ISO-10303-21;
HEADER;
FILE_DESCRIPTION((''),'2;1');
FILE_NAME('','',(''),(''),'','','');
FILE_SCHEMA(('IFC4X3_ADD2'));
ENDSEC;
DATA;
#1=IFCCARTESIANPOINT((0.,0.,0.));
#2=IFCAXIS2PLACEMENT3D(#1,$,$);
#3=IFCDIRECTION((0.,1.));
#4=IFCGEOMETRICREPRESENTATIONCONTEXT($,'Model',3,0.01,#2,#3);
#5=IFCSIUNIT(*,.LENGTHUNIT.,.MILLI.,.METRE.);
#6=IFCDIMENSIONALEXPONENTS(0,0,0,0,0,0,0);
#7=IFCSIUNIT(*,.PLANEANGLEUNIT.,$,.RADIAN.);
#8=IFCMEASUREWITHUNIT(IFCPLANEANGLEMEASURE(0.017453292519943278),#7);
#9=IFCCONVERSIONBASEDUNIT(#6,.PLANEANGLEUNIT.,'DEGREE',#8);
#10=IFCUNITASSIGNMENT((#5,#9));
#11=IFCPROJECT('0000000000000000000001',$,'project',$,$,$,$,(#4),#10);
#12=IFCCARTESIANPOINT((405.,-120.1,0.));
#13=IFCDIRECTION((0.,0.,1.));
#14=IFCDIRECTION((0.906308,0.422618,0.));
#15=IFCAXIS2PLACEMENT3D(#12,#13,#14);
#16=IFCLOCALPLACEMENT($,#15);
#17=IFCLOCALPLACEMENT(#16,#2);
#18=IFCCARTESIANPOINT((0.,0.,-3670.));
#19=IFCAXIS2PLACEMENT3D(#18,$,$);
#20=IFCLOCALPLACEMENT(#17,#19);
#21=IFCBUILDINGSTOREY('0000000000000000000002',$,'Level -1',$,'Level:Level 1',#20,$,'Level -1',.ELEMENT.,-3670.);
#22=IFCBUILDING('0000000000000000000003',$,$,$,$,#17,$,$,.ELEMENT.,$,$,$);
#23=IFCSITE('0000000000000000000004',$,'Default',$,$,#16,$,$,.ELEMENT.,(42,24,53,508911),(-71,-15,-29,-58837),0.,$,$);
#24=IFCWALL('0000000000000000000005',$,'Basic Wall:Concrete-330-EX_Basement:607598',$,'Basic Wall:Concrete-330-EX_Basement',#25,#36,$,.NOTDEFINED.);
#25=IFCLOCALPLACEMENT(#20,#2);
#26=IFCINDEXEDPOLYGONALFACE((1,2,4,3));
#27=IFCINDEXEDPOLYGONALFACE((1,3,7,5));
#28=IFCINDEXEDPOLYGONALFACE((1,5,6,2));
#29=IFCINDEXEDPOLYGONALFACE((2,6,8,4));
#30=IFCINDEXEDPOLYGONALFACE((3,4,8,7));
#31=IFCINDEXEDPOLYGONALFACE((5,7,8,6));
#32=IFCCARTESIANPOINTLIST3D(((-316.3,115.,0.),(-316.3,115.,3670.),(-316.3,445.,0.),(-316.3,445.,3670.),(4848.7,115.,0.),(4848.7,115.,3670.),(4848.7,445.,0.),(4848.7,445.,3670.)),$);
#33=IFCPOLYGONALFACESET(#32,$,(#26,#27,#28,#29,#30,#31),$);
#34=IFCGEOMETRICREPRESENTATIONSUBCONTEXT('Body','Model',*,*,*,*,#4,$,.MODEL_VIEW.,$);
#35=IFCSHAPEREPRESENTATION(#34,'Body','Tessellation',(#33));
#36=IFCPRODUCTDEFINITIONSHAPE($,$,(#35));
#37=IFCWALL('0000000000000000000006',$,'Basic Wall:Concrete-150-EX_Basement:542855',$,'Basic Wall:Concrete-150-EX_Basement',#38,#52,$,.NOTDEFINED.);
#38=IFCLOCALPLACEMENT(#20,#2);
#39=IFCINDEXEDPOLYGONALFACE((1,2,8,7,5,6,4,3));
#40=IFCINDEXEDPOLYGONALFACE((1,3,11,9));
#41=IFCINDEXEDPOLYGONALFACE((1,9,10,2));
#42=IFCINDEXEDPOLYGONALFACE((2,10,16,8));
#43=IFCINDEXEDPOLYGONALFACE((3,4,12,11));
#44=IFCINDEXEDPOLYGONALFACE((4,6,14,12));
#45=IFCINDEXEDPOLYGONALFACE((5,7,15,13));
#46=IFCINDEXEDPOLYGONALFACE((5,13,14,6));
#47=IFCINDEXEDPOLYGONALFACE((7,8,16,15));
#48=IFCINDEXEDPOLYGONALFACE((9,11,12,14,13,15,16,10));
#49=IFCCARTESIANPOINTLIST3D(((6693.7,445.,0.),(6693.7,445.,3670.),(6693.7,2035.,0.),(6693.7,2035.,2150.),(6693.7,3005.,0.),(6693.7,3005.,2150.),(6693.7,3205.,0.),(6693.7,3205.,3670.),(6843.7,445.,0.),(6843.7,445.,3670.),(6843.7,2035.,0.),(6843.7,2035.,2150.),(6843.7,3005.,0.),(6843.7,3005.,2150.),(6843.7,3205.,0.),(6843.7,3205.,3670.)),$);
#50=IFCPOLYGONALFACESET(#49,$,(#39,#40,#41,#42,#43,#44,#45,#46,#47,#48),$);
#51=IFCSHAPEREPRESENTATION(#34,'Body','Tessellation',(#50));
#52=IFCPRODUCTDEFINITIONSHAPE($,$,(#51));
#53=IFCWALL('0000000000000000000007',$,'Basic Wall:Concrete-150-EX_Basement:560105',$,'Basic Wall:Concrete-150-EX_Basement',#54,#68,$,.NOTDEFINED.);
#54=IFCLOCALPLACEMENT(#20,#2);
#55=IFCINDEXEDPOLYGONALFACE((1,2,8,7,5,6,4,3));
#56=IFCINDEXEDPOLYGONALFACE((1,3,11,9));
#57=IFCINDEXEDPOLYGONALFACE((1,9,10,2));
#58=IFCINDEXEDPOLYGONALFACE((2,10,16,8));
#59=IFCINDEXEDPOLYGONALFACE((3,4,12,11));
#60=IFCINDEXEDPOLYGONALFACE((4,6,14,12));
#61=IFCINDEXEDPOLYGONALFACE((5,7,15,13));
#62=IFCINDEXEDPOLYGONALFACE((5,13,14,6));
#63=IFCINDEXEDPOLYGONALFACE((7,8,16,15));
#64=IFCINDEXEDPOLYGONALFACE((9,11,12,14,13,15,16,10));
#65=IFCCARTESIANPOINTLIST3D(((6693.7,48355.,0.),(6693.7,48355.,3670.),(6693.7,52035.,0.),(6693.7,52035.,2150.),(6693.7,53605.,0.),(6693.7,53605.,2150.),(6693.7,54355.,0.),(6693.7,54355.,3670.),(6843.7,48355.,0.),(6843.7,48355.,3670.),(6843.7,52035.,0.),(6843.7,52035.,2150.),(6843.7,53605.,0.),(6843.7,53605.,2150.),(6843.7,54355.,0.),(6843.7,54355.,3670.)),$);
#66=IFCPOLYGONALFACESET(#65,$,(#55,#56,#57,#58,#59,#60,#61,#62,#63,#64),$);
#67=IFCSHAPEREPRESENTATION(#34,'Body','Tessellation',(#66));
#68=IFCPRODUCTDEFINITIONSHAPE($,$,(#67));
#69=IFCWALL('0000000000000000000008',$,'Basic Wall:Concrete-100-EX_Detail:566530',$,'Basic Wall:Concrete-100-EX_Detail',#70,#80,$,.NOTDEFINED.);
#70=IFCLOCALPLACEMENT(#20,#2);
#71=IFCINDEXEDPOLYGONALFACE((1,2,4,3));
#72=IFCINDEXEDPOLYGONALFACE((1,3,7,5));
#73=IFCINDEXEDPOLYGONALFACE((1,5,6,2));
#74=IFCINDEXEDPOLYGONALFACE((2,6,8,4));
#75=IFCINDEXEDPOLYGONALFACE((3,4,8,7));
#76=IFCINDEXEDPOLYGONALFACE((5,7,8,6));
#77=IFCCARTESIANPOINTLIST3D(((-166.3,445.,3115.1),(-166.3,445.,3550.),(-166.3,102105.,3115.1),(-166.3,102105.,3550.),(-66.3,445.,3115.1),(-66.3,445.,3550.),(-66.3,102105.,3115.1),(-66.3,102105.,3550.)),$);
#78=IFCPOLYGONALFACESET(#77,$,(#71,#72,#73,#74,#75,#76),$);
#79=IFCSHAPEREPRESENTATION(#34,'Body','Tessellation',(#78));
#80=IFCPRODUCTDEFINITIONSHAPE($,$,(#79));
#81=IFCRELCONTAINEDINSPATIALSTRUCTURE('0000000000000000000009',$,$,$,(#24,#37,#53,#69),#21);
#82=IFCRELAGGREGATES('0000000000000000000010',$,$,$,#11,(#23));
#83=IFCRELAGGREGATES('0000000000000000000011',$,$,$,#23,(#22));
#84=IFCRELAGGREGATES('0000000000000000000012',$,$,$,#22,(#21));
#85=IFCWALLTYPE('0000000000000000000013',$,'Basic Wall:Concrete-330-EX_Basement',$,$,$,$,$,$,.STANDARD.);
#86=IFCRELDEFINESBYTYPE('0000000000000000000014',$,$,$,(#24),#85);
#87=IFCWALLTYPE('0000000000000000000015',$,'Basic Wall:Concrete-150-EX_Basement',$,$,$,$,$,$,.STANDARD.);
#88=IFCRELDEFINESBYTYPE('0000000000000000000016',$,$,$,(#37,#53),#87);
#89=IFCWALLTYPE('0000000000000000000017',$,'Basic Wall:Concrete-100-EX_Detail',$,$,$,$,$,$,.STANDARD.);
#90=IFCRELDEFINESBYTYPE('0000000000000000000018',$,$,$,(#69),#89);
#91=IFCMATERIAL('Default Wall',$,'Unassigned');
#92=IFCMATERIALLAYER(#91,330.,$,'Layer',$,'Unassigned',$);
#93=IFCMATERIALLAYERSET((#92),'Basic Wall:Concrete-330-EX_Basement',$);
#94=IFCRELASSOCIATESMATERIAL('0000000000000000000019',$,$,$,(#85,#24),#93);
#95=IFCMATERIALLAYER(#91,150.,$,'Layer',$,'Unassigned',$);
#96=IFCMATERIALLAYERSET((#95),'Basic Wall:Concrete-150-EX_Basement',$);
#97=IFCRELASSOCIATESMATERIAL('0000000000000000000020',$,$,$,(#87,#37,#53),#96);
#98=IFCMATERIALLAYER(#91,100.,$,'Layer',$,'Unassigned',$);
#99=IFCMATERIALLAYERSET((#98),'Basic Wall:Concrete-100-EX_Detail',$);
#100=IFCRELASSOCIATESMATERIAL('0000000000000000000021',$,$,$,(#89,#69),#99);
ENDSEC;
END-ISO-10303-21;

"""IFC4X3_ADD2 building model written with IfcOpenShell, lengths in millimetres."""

from ifc_helpers import new_model, entity, si_unit, converted_unit, direction, frame, frame_2d, origin, place, context, subcontext, project, spatial, rectangle, extrude, material, layer, layer_set, type_object, element, save


model = new_model("IFC4X3_ADD2")

# Units and contexts
model_context = context("Model", 3, precision=0.01, world=origin(), true_north=direction((0.0, 1.0)))
body_context = subcontext(model_context, "Body", "Model", "MODEL_VIEW")
ifc_project = project(units=[si_unit("LENGTHUNIT", "METRE", prefix="MILLI"), converted_unit("PLANEANGLEUNIT", "DEGREE", entity("IfcPlaneAngleMeasure", 0.017453292519943278), si_unit("PLANEANGLEUNIT", "RADIAN"), dimensions=[0, 0, 0, 0, 0, 0, 0])], contexts=[model_context])

# Site, building, storey
site_placement = place(None, frame((405.0, -120.1, 0.0), z_axis=(0.0, 0.0, 1.0), x_axis=(0.906308, 0.422618, 0.0)))
site = spatial("IfcSite", under=ifc_project, at=site_placement, Name="Default", CompositionType="ELEMENT", RefLatitude=(42, 24, 53, 508911), RefLongitude=(-71, -15, -29, -58837), RefElevation=0.0)
building_placement = place(site_placement, origin())
building = spatial("IfcBuilding", under=site, at=building_placement, CompositionType="ELEMENT")
storey_placement = place(building_placement, frame((0.0, 0.0, -3670.0)))
storey = spatial("IfcBuildingStorey", under=building, at=storey_placement, Name="Level -1", ObjectType="Level:Level 1", LongName="Level -1", CompositionType="ELEMENT", Elevation=-3670.0)

# Shared definitions
ifc_material_1 = material(Name="Default Wall", Category="Unassigned")

# Wall
ifc_layer_1 = layer(ifc_material_1, 330.0, Name="Layer", Category="Unassigned")
ifc_layer_set_1 = layer_set([ifc_layer_1], Name="Basic Wall:Concrete-330-EX_Basement")
wall_type_1 = type_object("IfcWallType", Name="Basic Wall:Concrete-330-EX_Basement", PredefinedType="STANDARD", material=ifc_layer_set_1)
wall_1_placement = place(storey_placement, frame((4848.7, 280.0, 0.0), z_axis=(0.0, 0.0, 1.0), x_axis=(-1.0, 0.0, 0.0)))
element("IfcWall", 1, at=wall_1_placement, inside=storey, type_object=wall_type_1, material=ifc_layer_set_1, Name="Basic Wall:Concrete-330-EX_Basement:607598", ObjectType="Basic Wall:Concrete-330-EX_Basement", PredefinedType="NOTDEFINED", context=body_context, shape_type="SweptSolid", body=[
    extrude(rectangle(XDim=5165.0, YDim=330.0, at=frame_2d((2582.5, 0.0), x_axis=(-1.0, 0.0))), origin(), (0.0, 0.0, 1.0), 3670.0),
])

# Walls, openings
ifc_layer_2 = layer(ifc_material_1, 150.0, Name="Layer", Category="Unassigned")
ifc_layer_set_2 = layer_set([ifc_layer_2], Name="Basic Wall:Concrete-150-EX_Basement")
wall_type_2 = type_object("IfcWallType", Name="Basic Wall:Concrete-150-EX_Basement", PredefinedType="STANDARD", material=ifc_layer_set_2)
wall_2_placement = place(storey_placement, frame((6768.7, 3205.0, 0.0), z_axis=(0.0, 0.0, 1.0), x_axis=(0.0, -1.0, 0.0)))
wall_2 = element("IfcWall", 2, at=wall_2_placement, inside=storey, type_object=wall_type_2, material=ifc_layer_set_2, Name="Basic Wall:Concrete-150-EX_Basement:542855", ObjectType="Basic Wall:Concrete-150-EX_Basement", PredefinedType="NOTDEFINED", context=body_context, shape_type="SweptSolid", body=[
    extrude(rectangle(XDim=2760.0, YDim=150.0, at=frame_2d((1380.0, 0.0), x_axis=(-1.0, 0.0))), origin(), (0.0, 0.0, 1.0), 3670.0),
])
opening_1_placement = place(wall_2_placement, origin())
element("IfcOpeningElement", 3, at=opening_1_placement, cuts=wall_2, PredefinedType="OPENING", context=body_context, shape_type="SweptSolid", body=[
    extrude(rectangle(XDim=2150.0, YDim=970.0, at=frame_2d((0.0, 0.0), x_axis=(0.0, 1.0))), frame((685.0, 75.0, 1075.0), z_axis=(0.0, -1.0, 0.0), x_axis=(1.0, 0.0, 0.0)), (0.0, 0.0, 1.0), 150.0),
])
wall_3_placement = place(storey_placement, frame((6768.7, 48355.0, 0.0), z_axis=(0.0, 0.0, 1.0), x_axis=(0.0, 1.0, 0.0)))
wall_3 = element("IfcWall", 4, at=wall_3_placement, inside=storey, type_object=wall_type_2, material=ifc_layer_set_2, Name="Basic Wall:Concrete-150-EX_Basement:560105", ObjectType="Basic Wall:Concrete-150-EX_Basement", PredefinedType="NOTDEFINED", context=body_context, shape_type="SweptSolid", body=[
    extrude(rectangle(XDim=6000.0, YDim=150.0, at=frame_2d((3000.0, 0.0), x_axis=(-1.0, 0.0))), origin(), (0.0, 0.0, 1.0), 3670.0),
])
opening_2_placement = place(wall_3_placement, origin())
element("IfcOpeningElement", 5, at=opening_2_placement, cuts=wall_3, PredefinedType="OPENING", context=body_context, shape_type="SweptSolid", body=[
    extrude(rectangle(XDim=2150.0, YDim=1570.0, at=frame_2d((0.0, 0.0), x_axis=(0.0, 1.0))), frame((4465.0, 75.0, 1075.0), z_axis=(0.0, -1.0, 0.0), x_axis=(1.0, 0.0, 0.0)), (0.0, 0.0, 1.0), 150.0),
])

# Wall
ifc_layer_3 = layer(ifc_material_1, 100.0, Name="Layer", Category="Unassigned")
ifc_layer_set_3 = layer_set([ifc_layer_3], Name="Basic Wall:Concrete-100-EX_Detail")
wall_type_3 = type_object("IfcWallType", Name="Basic Wall:Concrete-100-EX_Detail", PredefinedType="STANDARD", material=ifc_layer_set_3)
wall_4_placement = place(storey_placement, frame((-116.3, 445.0, 3115.1), z_axis=(0.0, 0.0, 1.0), x_axis=(0.0, 1.0, 0.0)))
element("IfcWall", 6, at=wall_4_placement, inside=storey, type_object=wall_type_3, material=ifc_layer_set_3, Name="Basic Wall:Concrete-100-EX_Detail:566530", ObjectType="Basic Wall:Concrete-100-EX_Detail", PredefinedType="NOTDEFINED", context=body_context, shape_type="SweptSolid", body=[
    extrude(rectangle(XDim=101660.0, YDim=100.0, at=frame_2d((50830.0, 0.0), x_axis=(-1.0, 0.0))), origin(), (0.0, 0.0, 1.0), 434.9),
])

save(model, "model.ifc")
